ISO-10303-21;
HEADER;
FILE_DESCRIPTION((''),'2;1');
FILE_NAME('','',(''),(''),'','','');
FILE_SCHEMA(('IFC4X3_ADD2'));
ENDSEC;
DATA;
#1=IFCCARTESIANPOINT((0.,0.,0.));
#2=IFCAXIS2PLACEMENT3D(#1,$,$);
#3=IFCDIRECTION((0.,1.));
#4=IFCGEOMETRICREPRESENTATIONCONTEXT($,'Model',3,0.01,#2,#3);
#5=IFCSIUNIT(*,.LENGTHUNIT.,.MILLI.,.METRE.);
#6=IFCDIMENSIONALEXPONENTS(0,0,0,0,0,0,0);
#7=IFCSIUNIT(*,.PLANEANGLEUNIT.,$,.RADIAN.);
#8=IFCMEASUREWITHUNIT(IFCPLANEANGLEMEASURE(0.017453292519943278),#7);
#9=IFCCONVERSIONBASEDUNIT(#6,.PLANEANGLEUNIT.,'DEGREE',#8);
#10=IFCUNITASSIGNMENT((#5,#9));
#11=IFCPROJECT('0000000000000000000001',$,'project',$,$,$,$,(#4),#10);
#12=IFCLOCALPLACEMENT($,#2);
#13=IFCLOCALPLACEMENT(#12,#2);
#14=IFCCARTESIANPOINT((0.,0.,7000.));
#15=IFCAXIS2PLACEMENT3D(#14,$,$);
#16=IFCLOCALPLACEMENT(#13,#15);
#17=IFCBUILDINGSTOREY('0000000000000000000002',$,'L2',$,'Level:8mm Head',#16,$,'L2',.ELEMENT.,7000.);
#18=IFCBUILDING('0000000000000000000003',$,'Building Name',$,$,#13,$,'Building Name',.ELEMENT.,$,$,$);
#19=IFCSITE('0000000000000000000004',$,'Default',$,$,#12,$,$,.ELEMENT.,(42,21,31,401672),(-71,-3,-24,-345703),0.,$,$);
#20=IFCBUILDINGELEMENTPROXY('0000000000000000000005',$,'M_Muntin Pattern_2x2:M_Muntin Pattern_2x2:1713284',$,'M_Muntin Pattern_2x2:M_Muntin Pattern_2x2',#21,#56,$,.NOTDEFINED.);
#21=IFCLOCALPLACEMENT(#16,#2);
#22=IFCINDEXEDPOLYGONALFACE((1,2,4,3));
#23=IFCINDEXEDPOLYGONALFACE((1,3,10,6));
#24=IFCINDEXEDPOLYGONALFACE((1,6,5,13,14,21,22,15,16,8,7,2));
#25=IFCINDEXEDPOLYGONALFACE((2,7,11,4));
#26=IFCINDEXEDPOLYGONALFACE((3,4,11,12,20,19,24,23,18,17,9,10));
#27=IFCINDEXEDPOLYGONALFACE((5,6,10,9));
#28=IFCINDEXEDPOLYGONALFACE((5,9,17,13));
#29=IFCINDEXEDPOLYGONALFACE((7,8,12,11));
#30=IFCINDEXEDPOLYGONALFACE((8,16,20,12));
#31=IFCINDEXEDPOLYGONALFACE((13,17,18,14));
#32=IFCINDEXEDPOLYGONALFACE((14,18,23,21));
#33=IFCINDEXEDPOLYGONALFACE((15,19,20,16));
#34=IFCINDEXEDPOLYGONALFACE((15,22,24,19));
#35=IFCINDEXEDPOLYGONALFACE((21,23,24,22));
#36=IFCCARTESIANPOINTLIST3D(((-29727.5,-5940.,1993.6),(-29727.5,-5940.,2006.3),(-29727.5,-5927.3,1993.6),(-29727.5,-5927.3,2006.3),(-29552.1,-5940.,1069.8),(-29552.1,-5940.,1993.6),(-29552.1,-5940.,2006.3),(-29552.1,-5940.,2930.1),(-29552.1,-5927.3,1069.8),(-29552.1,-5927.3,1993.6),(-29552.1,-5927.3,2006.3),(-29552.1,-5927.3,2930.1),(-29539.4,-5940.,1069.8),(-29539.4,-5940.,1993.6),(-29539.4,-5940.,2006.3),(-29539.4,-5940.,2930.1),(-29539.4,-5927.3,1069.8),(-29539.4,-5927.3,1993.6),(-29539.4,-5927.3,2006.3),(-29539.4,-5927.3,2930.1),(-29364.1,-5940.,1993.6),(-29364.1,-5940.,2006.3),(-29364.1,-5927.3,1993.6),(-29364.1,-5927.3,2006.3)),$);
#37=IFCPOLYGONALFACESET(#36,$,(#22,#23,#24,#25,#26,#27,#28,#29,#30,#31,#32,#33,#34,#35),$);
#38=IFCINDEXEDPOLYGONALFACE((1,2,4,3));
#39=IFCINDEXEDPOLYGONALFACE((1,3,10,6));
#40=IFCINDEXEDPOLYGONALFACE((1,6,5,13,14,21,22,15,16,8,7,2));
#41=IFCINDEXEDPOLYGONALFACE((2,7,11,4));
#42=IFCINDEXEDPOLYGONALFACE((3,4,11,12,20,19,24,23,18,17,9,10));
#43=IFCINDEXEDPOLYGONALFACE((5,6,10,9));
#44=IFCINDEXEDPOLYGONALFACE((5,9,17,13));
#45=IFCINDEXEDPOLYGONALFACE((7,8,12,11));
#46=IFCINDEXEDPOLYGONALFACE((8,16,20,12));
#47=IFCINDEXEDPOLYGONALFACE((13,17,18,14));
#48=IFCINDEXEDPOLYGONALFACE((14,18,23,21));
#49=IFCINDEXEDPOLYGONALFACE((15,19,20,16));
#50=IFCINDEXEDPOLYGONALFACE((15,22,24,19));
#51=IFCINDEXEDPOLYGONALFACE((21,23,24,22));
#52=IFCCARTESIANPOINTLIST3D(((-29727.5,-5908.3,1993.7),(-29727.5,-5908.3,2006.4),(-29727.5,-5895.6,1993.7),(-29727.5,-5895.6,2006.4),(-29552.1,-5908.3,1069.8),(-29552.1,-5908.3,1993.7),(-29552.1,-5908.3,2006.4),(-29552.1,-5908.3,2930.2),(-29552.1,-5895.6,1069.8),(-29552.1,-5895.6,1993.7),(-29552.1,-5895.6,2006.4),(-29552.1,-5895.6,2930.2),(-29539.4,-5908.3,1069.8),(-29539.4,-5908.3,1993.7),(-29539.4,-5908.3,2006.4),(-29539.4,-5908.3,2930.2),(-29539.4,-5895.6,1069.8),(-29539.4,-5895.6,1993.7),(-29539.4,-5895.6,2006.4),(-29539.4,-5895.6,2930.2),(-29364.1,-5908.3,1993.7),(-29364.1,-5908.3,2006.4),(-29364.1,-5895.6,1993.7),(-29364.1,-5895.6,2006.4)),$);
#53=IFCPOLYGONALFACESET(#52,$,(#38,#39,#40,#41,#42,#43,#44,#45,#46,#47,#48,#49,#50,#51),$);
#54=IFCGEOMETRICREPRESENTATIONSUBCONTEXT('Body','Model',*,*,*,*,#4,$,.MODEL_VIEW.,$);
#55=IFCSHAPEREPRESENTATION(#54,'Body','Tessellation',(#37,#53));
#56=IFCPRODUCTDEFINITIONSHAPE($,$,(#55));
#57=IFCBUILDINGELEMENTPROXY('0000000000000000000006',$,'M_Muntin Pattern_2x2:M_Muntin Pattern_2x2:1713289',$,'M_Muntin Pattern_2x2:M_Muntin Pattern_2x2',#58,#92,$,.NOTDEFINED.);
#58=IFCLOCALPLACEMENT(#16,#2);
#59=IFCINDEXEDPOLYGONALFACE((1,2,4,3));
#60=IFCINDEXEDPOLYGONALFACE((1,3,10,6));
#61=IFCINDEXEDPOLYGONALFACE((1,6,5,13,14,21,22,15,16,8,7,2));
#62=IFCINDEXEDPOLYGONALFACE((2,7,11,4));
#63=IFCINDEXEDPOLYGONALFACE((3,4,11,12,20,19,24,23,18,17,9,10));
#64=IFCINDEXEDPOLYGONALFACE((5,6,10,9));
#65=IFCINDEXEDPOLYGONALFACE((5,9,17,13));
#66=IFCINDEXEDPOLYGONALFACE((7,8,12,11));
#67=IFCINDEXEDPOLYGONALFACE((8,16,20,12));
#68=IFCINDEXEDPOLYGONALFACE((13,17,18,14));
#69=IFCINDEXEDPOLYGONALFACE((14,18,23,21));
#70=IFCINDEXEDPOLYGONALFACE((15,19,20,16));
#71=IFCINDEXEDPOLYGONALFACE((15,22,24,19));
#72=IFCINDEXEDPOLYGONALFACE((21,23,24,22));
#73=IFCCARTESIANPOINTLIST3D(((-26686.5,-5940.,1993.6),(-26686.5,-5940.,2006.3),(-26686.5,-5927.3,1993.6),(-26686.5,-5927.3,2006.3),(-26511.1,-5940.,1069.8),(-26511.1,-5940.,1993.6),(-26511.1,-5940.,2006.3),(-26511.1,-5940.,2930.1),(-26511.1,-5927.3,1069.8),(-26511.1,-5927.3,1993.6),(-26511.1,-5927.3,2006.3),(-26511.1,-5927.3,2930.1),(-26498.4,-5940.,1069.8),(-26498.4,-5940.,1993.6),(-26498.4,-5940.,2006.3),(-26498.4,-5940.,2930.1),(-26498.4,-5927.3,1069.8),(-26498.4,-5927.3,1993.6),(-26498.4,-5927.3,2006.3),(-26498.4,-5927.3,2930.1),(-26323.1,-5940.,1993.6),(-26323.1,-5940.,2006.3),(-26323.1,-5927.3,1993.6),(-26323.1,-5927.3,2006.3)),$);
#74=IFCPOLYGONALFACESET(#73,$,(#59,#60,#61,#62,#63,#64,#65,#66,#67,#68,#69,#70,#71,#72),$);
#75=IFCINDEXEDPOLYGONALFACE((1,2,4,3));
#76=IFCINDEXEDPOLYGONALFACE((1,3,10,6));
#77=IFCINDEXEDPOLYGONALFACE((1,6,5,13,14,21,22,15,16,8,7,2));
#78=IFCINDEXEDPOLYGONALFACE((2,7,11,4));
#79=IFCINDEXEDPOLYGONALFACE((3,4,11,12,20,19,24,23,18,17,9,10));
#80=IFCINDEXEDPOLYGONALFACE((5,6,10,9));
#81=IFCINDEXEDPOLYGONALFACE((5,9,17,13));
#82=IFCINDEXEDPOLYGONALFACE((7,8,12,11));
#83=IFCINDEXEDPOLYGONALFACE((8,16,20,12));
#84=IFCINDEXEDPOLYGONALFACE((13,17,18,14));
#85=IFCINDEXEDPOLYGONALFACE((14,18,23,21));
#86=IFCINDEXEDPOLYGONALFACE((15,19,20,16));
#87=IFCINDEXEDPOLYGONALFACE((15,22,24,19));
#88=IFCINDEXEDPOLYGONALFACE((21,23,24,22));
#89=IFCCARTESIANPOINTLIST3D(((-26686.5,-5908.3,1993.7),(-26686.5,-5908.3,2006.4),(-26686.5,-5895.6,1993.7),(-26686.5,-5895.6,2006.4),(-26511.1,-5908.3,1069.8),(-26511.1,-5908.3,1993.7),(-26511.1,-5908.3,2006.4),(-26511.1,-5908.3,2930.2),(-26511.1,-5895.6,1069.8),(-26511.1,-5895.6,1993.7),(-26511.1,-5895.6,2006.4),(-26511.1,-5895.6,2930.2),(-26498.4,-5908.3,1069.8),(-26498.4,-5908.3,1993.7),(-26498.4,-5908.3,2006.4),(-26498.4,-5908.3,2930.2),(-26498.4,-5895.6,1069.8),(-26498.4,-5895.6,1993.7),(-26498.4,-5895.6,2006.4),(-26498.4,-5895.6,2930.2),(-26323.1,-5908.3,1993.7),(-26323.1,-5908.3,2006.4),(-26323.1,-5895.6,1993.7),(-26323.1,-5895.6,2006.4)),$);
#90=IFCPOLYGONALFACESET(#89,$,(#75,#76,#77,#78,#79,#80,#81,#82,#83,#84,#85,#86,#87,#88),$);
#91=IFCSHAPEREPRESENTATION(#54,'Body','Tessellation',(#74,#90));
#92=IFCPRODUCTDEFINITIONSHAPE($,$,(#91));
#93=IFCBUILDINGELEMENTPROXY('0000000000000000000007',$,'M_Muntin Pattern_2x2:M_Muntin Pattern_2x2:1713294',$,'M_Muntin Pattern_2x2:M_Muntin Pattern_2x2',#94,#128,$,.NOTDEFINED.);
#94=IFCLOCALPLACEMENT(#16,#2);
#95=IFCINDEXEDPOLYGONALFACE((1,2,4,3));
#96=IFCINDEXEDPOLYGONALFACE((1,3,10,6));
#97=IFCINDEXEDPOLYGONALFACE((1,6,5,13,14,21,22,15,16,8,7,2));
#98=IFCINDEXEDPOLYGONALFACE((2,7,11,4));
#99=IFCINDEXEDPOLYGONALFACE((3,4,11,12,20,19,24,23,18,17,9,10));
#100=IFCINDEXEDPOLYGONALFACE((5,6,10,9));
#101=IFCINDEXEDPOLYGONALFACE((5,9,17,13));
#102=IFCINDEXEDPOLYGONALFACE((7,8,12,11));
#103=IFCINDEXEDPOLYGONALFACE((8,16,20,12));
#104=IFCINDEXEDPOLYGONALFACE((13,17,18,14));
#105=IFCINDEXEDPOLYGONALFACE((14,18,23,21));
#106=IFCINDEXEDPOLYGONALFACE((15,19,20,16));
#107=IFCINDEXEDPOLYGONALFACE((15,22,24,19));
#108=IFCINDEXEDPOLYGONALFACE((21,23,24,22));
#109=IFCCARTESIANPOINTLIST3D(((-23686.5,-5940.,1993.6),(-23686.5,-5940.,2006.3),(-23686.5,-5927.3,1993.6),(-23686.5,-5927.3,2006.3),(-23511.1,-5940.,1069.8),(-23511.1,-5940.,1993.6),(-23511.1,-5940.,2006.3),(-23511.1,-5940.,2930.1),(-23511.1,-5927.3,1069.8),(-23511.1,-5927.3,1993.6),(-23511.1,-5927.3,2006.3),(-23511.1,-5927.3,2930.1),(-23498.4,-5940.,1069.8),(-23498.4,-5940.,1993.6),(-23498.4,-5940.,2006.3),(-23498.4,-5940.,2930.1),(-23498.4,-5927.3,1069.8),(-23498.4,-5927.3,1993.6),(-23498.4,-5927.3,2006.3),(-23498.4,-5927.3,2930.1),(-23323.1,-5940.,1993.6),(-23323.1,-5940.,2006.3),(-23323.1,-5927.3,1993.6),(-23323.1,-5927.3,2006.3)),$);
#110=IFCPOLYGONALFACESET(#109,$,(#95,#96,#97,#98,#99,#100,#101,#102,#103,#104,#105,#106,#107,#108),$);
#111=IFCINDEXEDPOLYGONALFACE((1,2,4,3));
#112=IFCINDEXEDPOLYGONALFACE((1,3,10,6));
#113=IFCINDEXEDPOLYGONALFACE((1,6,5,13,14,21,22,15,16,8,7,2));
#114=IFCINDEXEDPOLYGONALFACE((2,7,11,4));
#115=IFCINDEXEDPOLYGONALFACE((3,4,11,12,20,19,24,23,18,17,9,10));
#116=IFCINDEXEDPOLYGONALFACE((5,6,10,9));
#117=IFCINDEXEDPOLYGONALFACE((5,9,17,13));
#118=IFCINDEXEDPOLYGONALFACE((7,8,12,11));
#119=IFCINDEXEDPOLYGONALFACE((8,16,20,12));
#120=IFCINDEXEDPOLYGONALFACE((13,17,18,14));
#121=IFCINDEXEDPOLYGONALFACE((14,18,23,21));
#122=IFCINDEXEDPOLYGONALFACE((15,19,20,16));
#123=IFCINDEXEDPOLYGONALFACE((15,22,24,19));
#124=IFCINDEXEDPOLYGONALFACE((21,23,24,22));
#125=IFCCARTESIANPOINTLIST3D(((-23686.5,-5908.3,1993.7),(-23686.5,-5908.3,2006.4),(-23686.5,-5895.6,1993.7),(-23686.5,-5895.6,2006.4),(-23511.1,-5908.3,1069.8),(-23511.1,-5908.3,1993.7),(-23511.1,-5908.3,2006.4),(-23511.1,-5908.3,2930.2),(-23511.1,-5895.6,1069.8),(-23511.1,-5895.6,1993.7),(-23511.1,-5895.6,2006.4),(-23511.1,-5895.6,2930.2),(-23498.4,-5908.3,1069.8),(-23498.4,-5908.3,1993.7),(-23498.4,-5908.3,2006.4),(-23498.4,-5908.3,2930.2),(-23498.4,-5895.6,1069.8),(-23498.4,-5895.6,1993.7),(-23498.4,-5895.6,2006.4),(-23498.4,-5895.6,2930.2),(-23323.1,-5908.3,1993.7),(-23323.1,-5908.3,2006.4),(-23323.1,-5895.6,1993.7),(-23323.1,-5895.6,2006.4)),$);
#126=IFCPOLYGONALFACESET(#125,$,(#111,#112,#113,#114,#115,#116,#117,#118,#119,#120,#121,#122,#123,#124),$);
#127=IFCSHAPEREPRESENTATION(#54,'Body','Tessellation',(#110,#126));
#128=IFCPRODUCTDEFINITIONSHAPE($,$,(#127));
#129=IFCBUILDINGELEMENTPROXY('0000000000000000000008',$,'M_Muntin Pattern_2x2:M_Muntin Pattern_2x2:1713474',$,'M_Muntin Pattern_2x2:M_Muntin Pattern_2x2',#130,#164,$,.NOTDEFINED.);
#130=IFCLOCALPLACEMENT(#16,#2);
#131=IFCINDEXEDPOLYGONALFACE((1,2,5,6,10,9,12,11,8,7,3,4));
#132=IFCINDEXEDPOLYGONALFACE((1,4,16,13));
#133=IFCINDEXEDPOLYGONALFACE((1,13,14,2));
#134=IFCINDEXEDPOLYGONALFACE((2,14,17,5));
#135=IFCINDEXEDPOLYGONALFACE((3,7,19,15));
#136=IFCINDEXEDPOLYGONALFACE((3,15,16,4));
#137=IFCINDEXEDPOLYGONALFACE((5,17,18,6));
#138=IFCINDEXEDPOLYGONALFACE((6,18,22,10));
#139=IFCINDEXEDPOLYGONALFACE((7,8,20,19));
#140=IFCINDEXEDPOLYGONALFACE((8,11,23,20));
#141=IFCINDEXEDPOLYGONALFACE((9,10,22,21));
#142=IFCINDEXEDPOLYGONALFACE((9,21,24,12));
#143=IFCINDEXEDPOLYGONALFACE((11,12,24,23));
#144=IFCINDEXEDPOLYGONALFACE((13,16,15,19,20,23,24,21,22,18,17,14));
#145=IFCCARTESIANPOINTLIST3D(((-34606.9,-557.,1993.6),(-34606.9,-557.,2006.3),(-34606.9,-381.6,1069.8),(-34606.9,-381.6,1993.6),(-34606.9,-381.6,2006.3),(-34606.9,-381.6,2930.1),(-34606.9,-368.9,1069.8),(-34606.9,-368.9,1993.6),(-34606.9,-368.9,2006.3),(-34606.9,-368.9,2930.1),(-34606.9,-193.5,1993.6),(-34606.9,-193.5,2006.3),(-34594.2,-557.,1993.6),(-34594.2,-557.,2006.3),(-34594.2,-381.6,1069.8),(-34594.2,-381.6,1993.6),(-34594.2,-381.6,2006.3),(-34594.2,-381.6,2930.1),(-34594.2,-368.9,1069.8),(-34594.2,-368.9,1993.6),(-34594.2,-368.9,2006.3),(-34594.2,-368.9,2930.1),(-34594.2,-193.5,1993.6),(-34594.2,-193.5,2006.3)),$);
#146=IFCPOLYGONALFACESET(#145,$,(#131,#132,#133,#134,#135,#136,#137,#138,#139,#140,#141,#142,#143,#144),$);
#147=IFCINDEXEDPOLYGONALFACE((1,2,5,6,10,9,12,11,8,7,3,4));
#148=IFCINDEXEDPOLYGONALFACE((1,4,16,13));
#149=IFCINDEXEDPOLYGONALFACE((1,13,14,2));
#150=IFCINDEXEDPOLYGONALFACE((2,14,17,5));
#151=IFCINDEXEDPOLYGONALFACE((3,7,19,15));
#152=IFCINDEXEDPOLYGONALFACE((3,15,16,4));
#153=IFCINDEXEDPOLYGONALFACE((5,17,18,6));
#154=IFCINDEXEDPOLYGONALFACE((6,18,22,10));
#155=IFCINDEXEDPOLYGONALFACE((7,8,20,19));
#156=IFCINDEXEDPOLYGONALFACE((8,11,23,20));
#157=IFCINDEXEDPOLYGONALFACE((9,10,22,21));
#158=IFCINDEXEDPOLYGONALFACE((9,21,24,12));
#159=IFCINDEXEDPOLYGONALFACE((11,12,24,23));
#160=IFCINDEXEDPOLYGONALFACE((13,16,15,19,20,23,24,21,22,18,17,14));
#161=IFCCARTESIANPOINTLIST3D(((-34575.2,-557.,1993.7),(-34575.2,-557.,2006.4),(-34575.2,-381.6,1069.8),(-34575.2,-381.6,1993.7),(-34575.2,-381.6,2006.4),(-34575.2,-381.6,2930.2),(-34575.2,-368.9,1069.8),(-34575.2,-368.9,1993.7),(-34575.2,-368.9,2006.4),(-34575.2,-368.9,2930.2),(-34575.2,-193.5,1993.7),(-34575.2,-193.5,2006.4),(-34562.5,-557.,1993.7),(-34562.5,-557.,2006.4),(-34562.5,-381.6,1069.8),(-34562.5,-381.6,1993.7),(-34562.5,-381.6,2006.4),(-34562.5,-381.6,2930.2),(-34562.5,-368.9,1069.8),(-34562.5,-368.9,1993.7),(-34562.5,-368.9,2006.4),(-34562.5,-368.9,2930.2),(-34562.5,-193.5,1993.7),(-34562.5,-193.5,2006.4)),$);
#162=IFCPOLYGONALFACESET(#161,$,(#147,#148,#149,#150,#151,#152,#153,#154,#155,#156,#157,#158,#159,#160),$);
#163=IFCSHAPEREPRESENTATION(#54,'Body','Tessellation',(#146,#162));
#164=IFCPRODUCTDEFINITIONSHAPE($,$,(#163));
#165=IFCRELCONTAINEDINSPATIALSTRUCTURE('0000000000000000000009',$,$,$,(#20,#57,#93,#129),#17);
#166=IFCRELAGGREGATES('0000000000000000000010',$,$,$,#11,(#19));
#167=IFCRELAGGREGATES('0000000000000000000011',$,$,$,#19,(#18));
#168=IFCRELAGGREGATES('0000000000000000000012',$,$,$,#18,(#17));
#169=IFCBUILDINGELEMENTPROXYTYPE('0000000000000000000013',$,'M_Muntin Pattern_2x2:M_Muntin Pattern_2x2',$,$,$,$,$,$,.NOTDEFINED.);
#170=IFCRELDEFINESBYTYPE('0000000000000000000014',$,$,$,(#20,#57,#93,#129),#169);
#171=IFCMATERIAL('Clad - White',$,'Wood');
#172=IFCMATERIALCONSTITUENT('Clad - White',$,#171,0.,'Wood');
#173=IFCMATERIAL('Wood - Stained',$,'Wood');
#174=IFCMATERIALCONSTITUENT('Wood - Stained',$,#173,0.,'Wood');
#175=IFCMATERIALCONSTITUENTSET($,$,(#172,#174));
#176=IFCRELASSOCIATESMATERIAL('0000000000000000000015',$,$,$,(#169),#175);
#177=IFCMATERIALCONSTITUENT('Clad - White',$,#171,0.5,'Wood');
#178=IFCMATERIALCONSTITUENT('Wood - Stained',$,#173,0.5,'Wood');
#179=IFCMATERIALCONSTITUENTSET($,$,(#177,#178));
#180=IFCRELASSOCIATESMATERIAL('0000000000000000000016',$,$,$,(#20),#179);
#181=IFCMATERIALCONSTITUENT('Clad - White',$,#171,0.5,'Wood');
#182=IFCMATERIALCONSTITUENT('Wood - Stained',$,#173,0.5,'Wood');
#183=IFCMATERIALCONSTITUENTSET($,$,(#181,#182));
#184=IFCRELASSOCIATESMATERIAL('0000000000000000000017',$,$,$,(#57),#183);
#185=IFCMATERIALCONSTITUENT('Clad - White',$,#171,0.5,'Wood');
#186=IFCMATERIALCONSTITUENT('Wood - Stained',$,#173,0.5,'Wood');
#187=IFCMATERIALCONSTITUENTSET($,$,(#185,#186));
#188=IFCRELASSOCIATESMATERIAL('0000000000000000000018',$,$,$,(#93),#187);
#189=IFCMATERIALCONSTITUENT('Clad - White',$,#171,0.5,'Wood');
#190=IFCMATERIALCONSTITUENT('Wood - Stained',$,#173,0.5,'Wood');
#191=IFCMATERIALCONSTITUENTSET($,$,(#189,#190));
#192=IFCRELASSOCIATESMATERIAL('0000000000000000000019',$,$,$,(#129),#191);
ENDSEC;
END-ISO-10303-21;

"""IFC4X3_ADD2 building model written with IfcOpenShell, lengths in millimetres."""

from ifc_helpers import new_model, entity, si_unit, converted_unit, direction, frame, origin, place, context, subcontext, project, spatial, polyline, outline, extrude, source, transform, mapped, material, constituent, constituent_set, type_object, type_shapes, element, save


model = new_model("IFC4X3_ADD2")

# Units and contexts
model_context = context("Model", 3, precision=0.01, world=origin(), true_north=direction((0.0, 1.0)))
body_context = subcontext(model_context, "Body", "Model", "MODEL_VIEW")
ifc_project = project(units=[si_unit("LENGTHUNIT", "METRE", prefix="MILLI"), converted_unit("PLANEANGLEUNIT", "DEGREE", entity("IfcPlaneAngleMeasure", 0.017453292519943278), si_unit("PLANEANGLEUNIT", "RADIAN"), dimensions=[0, 0, 0, 0, 0, 0, 0])], contexts=[model_context])

# Site, building, storey
site_placement = place(None, origin())
site = spatial("IfcSite", under=ifc_project, at=site_placement, Name="Default", CompositionType="ELEMENT", RefLatitude=(42, 21, 31, 401672), RefLongitude=(-71, -3, -24, -345703), RefElevation=0.0)
building_placement = place(site_placement, origin())
building = spatial("IfcBuilding", under=site, at=building_placement, Name="Building Name", LongName="Building Name", CompositionType="ELEMENT")
storey_placement = place(building_placement, frame((0.0, 0.0, 7000.0)))
storey = spatial("IfcBuildingStorey", under=building, at=storey_placement, Name="L2", ObjectType="Level:8mm Head", LongName="L2", CompositionType="ELEMENT", Elevation=7000.0)

# Building element proxies
ifc_material_1 = material(Name="Clad - White", Category="Wood")
ifc_material_2 = material(Name="Wood - Stained", Category="Wood")
ifc_constituent_1 = constituent(ifc_material_1, Name="Clad - White", Category="Wood", fraction=0.0)
ifc_constituent_2 = constituent(ifc_material_2, Name="Wood - Stained", Category="Wood", fraction=0.0)
ifc_constituent_set_1 = constituent_set(constituents=[ifc_constituent_1, ifc_constituent_2])
building_element_proxy_type_1 = type_object("IfcBuildingElementProxyType", Name="M_Muntin Pattern_2x2:M_Muntin Pattern_2x2", PredefinedType="NOTDEFINED", material=ifc_constituent_set_1)
shared_shape_1 = source(origin(), body_context, "Body", "SweptSolid", [
    extrude(outline(polyline([(6.4, -6.4), (930.1, -6.4), (930.1, 6.3), (6.4, 6.3), (6.4, 181.7), (-6.3, 181.7), (-6.3, 6.3), (-930.2, 6.3), (-930.2, -6.4), (-6.3, -6.4), (-6.3, -181.7), (6.4, -181.7), (6.4, -6.4)])), frame((0.0, 9.5, 930.1), z_axis=(0.0, 1.0, 0.0), x_axis=(0.0, 0.0, 1.0)), (0.0, 0.0, 1.0), 12.7),
    extrude(outline(polyline([(6.4, -6.4), (930.2, -6.4), (930.2, 6.3), (6.4, 6.3), (6.4, 181.7), (-6.3, 181.7), (-6.3, 6.3), (-930.2, 6.3), (-930.2, -6.4), (-6.3, -6.4), (-6.3, -181.7), (6.4, -181.7), (6.4, -6.4)])), frame((0.0, -22.2, 930.2), z_axis=(0.0, 1.0, 0.0), x_axis=(0.0, 0.0, 1.0)), (0.0, 0.0, 1.0), 12.7),
])
type_shapes(building_element_proxy_type_1, [shared_shape_1])
ifc_constituent_3 = constituent(ifc_material_1, Name="Clad - White", Category="Wood", fraction=0.5)
ifc_constituent_4 = constituent(ifc_material_2, Name="Wood - Stained", Category="Wood", fraction=0.5)
ifc_constituent_set_2 = constituent_set(constituents=[ifc_constituent_3, ifc_constituent_4])
proxy_1_placement = place(storey_placement, frame((-29545.8, -5917.8, 1069.8), z_axis=(0.0, 0.0, 1.0), x_axis=(-1.0, 0.0, 0.0)))
element("IfcBuildingElementProxy", 1, at=proxy_1_placement, inside=storey, type_object=building_element_proxy_type_1, material=ifc_constituent_set_2, Name="M_Muntin Pattern_2x2:M_Muntin Pattern_2x2:1713284", ObjectType="M_Muntin Pattern_2x2:M_Muntin Pattern_2x2", PredefinedType="NOTDEFINED", context=body_context, shape_type="MappedRepresentation", body=[
    mapped(shared_shape_1, transform((0.0, 0.0, 0.0), scale=1.0)),
])
ifc_constituent_5 = constituent(ifc_material_1, Name="Clad - White", Category="Wood", fraction=0.5)
ifc_constituent_6 = constituent(ifc_material_2, Name="Wood - Stained", Category="Wood", fraction=0.5)
ifc_constituent_set_3 = constituent_set(constituents=[ifc_constituent_5, ifc_constituent_6])
proxy_2_placement = place(storey_placement, frame((-26504.8, -5917.8, 1069.8), z_axis=(0.0, 0.0, 1.0), x_axis=(-1.0, 0.0, 0.0)))
element("IfcBuildingElementProxy", 2, at=proxy_2_placement, inside=storey, type_object=building_element_proxy_type_1, material=ifc_constituent_set_3, Name="M_Muntin Pattern_2x2:M_Muntin Pattern_2x2:1713289", ObjectType="M_Muntin Pattern_2x2:M_Muntin Pattern_2x2", PredefinedType="NOTDEFINED", context=body_context, shape_type="MappedRepresentation", body=[
    mapped(shared_shape_1, transform((0.0, 0.0, 0.0), scale=1.0)),
])
ifc_constituent_7 = constituent(ifc_material_1, Name="Clad - White", Category="Wood", fraction=0.5)
ifc_constituent_8 = constituent(ifc_material_2, Name="Wood - Stained", Category="Wood", fraction=0.5)
ifc_constituent_set_4 = constituent_set(constituents=[ifc_constituent_7, ifc_constituent_8])
proxy_3_placement = place(storey_placement, frame((-23504.8, -5917.8, 1069.8), z_axis=(0.0, 0.0, 1.0), x_axis=(-1.0, 0.0, 0.0)))
element("IfcBuildingElementProxy", 3, at=proxy_3_placement, inside=storey, type_object=building_element_proxy_type_1, material=ifc_constituent_set_4, Name="M_Muntin Pattern_2x2:M_Muntin Pattern_2x2:1713294", ObjectType="M_Muntin Pattern_2x2:M_Muntin Pattern_2x2", PredefinedType="NOTDEFINED", context=body_context, shape_type="MappedRepresentation", body=[
    mapped(shared_shape_1, transform((0.0, 0.0, 0.0), scale=1.0)),
])
ifc_constituent_9 = constituent(ifc_material_1, Name="Clad - White", Category="Wood", fraction=0.5)
ifc_constituent_10 = constituent(ifc_material_2, Name="Wood - Stained", Category="Wood", fraction=0.5)
ifc_constituent_set_5 = constituent_set(constituents=[ifc_constituent_9, ifc_constituent_10])
proxy_4_placement = place(storey_placement, frame((-34584.7, -375.2, 1069.8), z_axis=(0.0, 0.0, 1.0), x_axis=(0.0, 1.0, 0.0)))
element("IfcBuildingElementProxy", 4, at=proxy_4_placement, inside=storey, type_object=building_element_proxy_type_1, material=ifc_constituent_set_5, Name="M_Muntin Pattern_2x2:M_Muntin Pattern_2x2:1713474", ObjectType="M_Muntin Pattern_2x2:M_Muntin Pattern_2x2", PredefinedType="NOTDEFINED", context=body_context, shape_type="MappedRepresentation", body=[
    mapped(shared_shape_1, transform((0.0, 0.0, 0.0), scale=1.0)),
])

save(model, "model.ifc")
